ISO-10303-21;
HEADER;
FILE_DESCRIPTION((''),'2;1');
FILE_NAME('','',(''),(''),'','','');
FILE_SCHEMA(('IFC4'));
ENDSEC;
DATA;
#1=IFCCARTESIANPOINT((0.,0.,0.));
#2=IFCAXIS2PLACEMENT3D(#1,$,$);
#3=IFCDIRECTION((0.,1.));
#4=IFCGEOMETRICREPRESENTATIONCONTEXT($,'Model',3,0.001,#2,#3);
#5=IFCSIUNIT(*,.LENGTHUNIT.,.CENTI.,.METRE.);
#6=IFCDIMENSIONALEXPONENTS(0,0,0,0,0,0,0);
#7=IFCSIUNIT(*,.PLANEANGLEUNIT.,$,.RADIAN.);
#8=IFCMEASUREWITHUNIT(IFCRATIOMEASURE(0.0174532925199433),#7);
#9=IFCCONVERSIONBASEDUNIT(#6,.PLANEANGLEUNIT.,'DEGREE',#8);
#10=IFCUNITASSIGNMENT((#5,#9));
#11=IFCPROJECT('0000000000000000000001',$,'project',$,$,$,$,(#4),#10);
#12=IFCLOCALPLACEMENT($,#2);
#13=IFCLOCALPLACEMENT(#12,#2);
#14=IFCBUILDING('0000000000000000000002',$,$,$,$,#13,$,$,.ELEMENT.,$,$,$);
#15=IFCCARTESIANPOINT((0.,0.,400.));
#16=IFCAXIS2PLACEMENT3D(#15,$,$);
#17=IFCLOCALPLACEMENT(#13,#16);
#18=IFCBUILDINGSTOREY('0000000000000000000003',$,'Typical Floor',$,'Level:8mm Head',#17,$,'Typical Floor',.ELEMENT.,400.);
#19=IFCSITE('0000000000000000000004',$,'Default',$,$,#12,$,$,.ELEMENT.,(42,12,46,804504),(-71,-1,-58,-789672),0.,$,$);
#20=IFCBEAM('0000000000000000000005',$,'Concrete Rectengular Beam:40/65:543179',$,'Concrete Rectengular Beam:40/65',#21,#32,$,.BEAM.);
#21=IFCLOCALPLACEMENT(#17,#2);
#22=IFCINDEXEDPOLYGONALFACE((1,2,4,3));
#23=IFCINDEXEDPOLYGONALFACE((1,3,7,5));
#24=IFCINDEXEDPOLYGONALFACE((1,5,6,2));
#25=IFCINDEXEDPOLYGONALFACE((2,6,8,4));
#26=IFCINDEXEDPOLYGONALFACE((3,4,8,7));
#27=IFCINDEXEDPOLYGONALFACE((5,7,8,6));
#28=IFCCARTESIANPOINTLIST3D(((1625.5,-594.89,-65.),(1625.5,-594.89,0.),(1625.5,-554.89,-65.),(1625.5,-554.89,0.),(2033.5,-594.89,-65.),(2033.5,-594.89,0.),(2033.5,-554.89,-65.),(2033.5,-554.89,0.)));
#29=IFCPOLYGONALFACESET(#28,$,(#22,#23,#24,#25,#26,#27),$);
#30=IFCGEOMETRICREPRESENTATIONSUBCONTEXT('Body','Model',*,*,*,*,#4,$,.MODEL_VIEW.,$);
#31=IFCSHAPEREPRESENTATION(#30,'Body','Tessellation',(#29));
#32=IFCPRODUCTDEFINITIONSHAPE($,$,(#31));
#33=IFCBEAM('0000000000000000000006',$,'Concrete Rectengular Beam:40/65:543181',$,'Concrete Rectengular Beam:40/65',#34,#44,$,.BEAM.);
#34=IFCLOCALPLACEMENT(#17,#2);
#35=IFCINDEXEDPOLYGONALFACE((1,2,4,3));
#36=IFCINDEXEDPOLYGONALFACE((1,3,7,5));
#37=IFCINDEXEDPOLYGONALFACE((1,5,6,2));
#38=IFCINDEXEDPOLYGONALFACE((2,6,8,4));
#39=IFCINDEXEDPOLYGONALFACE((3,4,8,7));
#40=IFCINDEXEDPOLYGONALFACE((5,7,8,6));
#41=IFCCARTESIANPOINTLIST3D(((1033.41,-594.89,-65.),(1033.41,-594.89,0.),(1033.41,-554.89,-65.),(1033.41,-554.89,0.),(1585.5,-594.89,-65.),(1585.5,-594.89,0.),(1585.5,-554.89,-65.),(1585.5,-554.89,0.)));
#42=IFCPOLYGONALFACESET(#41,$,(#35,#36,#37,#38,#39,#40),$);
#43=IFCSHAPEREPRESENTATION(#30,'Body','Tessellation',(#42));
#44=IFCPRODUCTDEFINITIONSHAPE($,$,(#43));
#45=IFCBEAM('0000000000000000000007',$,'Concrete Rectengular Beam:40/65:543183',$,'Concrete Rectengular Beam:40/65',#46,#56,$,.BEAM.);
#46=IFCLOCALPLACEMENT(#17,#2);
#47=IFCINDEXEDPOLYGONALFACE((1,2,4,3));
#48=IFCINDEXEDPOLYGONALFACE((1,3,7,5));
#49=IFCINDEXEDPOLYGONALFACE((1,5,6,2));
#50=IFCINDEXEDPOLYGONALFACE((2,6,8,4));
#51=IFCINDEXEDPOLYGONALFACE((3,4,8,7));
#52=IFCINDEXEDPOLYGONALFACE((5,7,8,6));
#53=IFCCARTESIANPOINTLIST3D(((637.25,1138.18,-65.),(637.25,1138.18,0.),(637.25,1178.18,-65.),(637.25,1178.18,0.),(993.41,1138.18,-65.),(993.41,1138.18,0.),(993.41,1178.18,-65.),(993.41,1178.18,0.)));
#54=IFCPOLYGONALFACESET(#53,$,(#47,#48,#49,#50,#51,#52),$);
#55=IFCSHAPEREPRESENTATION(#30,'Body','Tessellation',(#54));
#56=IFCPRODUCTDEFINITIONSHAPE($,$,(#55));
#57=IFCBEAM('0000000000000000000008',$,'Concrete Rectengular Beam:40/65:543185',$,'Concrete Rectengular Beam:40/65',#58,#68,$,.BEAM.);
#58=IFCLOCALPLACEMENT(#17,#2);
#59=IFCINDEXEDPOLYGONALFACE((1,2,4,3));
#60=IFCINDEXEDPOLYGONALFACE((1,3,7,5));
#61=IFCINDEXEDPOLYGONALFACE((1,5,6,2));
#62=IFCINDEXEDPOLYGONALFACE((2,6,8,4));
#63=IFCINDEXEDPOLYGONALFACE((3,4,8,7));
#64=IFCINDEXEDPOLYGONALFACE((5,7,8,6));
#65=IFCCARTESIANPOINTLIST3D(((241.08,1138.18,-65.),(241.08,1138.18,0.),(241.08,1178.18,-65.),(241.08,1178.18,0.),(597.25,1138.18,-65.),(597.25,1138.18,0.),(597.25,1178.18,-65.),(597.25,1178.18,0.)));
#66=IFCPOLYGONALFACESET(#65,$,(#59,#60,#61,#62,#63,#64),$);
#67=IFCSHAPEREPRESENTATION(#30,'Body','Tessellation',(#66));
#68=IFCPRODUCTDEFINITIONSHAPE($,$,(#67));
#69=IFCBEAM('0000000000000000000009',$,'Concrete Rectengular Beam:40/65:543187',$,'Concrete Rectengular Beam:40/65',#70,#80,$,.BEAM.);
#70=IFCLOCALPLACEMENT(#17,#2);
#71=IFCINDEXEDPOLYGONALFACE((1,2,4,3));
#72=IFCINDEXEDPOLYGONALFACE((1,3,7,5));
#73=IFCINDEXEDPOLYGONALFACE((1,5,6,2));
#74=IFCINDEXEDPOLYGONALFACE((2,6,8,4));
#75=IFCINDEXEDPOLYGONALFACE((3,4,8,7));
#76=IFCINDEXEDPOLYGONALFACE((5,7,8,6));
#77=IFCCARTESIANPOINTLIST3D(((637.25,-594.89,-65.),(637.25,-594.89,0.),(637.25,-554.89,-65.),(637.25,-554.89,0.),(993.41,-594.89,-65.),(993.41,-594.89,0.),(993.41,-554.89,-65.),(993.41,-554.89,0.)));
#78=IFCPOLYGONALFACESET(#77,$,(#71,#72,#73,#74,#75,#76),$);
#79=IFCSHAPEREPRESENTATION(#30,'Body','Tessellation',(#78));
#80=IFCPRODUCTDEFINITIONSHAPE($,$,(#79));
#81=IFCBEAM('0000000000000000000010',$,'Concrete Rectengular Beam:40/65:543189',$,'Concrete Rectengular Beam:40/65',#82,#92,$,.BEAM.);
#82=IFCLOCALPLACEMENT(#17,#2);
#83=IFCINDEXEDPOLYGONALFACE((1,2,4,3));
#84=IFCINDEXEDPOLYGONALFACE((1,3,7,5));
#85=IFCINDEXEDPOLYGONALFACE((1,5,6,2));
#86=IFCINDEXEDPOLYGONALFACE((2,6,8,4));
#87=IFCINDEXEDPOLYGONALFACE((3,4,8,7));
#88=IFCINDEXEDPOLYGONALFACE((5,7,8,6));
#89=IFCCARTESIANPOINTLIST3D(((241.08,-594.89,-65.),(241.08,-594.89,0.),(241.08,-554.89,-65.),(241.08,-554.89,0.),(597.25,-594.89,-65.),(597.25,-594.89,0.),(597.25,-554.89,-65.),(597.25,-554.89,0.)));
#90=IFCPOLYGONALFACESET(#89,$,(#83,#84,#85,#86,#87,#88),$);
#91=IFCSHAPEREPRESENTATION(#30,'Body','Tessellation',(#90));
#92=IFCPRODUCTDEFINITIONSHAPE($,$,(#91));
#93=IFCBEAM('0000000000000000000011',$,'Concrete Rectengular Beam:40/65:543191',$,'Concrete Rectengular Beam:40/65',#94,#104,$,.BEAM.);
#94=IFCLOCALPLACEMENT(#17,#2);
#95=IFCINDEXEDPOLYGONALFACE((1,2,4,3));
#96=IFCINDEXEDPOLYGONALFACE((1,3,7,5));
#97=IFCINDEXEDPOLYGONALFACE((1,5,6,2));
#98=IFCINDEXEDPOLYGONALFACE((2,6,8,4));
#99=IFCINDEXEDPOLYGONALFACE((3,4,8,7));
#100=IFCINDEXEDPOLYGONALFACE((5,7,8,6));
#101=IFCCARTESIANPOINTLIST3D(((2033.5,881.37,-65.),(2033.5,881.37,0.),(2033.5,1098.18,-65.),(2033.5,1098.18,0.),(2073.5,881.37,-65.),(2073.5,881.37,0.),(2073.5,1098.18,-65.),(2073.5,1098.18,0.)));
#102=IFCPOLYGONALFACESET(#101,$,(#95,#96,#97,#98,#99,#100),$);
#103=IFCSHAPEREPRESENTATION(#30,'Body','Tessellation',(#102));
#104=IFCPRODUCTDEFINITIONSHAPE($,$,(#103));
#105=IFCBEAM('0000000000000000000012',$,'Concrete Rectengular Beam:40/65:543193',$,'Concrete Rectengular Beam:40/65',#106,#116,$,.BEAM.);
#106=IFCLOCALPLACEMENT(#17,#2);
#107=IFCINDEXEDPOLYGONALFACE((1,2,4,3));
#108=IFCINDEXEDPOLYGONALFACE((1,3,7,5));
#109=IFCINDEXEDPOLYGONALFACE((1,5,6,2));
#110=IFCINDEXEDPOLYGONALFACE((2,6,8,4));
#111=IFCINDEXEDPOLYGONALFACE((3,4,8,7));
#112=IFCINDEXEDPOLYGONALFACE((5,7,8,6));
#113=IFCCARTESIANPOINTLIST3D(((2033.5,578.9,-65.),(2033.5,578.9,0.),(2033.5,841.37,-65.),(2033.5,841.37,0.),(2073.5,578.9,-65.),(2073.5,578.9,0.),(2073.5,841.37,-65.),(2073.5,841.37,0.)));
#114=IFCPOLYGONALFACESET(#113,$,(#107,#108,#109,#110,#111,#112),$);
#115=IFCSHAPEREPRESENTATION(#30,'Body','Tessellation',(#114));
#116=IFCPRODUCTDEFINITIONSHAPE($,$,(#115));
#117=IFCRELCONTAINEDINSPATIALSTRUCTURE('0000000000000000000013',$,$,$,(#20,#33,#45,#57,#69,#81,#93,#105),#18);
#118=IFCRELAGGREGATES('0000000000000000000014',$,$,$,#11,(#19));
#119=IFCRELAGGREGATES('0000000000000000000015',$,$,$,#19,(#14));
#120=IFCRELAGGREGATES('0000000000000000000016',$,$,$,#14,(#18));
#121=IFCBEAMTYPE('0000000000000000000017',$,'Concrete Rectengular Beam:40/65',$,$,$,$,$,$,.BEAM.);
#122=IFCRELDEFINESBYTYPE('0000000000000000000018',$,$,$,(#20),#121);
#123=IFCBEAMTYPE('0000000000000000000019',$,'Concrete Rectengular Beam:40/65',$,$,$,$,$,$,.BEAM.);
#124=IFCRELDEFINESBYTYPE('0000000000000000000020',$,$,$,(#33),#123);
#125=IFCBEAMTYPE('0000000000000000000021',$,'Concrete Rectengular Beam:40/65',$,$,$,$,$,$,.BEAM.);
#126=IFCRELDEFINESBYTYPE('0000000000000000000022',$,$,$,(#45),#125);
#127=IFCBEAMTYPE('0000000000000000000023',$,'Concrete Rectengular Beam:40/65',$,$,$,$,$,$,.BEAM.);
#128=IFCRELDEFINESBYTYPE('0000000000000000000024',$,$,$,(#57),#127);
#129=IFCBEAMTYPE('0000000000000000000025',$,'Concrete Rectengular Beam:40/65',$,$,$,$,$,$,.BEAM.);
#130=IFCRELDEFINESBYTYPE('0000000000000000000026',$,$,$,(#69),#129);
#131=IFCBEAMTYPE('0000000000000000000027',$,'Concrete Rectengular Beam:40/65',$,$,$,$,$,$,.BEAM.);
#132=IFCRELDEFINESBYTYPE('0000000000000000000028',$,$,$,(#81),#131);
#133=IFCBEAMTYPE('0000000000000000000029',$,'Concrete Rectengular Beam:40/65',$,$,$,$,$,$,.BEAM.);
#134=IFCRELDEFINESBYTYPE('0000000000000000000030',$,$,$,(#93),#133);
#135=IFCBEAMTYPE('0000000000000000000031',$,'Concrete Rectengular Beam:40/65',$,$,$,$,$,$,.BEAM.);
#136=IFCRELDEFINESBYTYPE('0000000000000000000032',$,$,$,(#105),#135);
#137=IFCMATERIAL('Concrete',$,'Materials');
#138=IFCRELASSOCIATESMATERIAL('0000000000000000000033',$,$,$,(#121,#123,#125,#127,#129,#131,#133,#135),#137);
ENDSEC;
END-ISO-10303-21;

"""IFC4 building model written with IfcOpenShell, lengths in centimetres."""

from ifc_helpers import new_model, entity, si_unit, converted_unit, direction, frame, origin, place, context, subcontext, project, spatial, indexed_curve, outline, extrude, source, transform, mapped, material, type_object, type_shapes, element, save


model = new_model("IFC4")

# Units and contexts
model_context = context("Model", 3, precision=0.001, world=origin(), true_north=direction((0.0, 1.0)))
body_context = subcontext(model_context, "Body", "Model", "MODEL_VIEW")
ifc_project = project(units=[si_unit("LENGTHUNIT", "METRE", prefix="CENTI"), converted_unit("PLANEANGLEUNIT", "DEGREE", entity("IfcRatioMeasure", 0.0174532925199433), si_unit("PLANEANGLEUNIT", "RADIAN"), dimensions=[0, 0, 0, 0, 0, 0, 0])], contexts=[model_context])

# Site, building, storey
site_placement = place(None, origin())
site = spatial("IfcSite", under=ifc_project, at=site_placement, Name="Default", CompositionType="ELEMENT", RefLatitude=(42, 12, 46, 804504), RefLongitude=(-71, -1, -58, -789672), RefElevation=0.0)
building_placement = place(site_placement, origin())
building = spatial("IfcBuilding", under=site, at=building_placement, CompositionType="ELEMENT")
storey_placement = place(building_placement, frame((0.0, 0.0, 400.0)))
storey = spatial("IfcBuildingStorey", under=building, at=storey_placement, Name="Typical Floor", ObjectType="Level:8mm Head", LongName="Typical Floor", CompositionType="ELEMENT", Elevation=400.0)

# Beams
ifc_material = material(Name="Concrete", Category="Materials")
beam_type_1 = type_object("IfcBeamType", Name="Concrete Rectengular Beam:40/65", PredefinedType="BEAM", material=ifc_material)
shared_shape_1 = source(origin(), body_context, "Body", "SweptSolid", [
    extrude(outline(indexed_curve([(-32.5, -20.0), (32.5, -20.0), (32.5, 20.0), (-32.5, 20.0), (-32.5, -20.0)], self_intersect=False)), frame((2033.5, -574.89, 367.5), z_axis=(-1.0, 0.0, 0.0), x_axis=(0.0, 0.0, -1.0)), (0.0, 0.0, 1.0), 408.0),
])
type_shapes(beam_type_1, [shared_shape_1])
beam_1_placement = place(storey_placement, frame((0.0, 0.0, -400.0)))
element("IfcBeam", 1, at=beam_1_placement, inside=storey, type_object=beam_type_1, Name="Concrete Rectengular Beam:40/65:543179", ObjectType="Concrete Rectengular Beam:40/65", PredefinedType="BEAM", context=body_context, shape_type="MappedRepresentation", body=[
    mapped(shared_shape_1, transform((0.0, 0.0, 0.0), scale=1.0)),
])
beam_type_2 = type_object("IfcBeamType", Name="Concrete Rectengular Beam:40/65", PredefinedType="BEAM", material=ifc_material)
shared_shape_2 = source(origin(), body_context, "Body", "SweptSolid", [
    extrude(outline(indexed_curve([(-32.5, -20.0), (32.5, -20.0), (32.5, 20.0), (-32.5, 20.0), (-32.5, -20.0)], self_intersect=False)), frame((1585.5, -574.89, 367.5), z_axis=(-1.0, 0.0, 0.0), x_axis=(0.0, 0.0, -1.0)), (0.0, 0.0, 1.0), 552.09),
])
type_shapes(beam_type_2, [shared_shape_2])
beam_2_placement = place(storey_placement, frame((0.0, 0.0, -400.0)))
element("IfcBeam", 2, at=beam_2_placement, inside=storey, type_object=beam_type_2, Name="Concrete Rectengular Beam:40/65:543181", ObjectType="Concrete Rectengular Beam:40/65", PredefinedType="BEAM", context=body_context, shape_type="MappedRepresentation", body=[
    mapped(shared_shape_2, transform((0.0, 0.0, 0.0), scale=1.0)),
])
beam_type_3 = type_object("IfcBeamType", Name="Concrete Rectengular Beam:40/65", PredefinedType="BEAM", material=ifc_material)
shared_shape_3 = source(origin(), body_context, "Body", "SweptSolid", [
    extrude(outline(indexed_curve([(-32.5, -20.0), (32.5, -20.0), (32.5, 20.0), (-32.5, 20.0), (-32.5, -20.0)], self_intersect=False)), frame((993.41, 1158.18, 367.5), z_axis=(-1.0, 0.0, 0.0), x_axis=(0.0, 0.0, -1.0)), (0.0, 0.0, 1.0), 356.17),
])
type_shapes(beam_type_3, [shared_shape_3])
beam_3_placement = place(storey_placement, frame((0.0, 0.0, -400.0)))
element("IfcBeam", 3, at=beam_3_placement, inside=storey, type_object=beam_type_3, Name="Concrete Rectengular Beam:40/65:543183", ObjectType="Concrete Rectengular Beam:40/65", PredefinedType="BEAM", context=body_context, shape_type="MappedRepresentation", body=[
    mapped(shared_shape_3, transform((0.0, 0.0, 0.0), scale=1.0)),
])
beam_type_4 = type_object("IfcBeamType", Name="Concrete Rectengular Beam:40/65", PredefinedType="BEAM", material=ifc_material)
shared_shape_4 = source(origin(), body_context, "Body", "SweptSolid", [
    extrude(outline(indexed_curve([(-32.5, -20.0), (32.5, -20.0), (32.5, 20.0), (-32.5, 20.0), (-32.5, -20.0)], self_intersect=False)), frame((597.25, 1158.18, 367.5), z_axis=(-1.0, 0.0, 0.0), x_axis=(0.0, 0.0, -1.0)), (0.0, 0.0, 1.0), 356.17),
])
type_shapes(beam_type_4, [shared_shape_4])
beam_4_placement = place(storey_placement, frame((0.0, 0.0, -400.0)))
element("IfcBeam", 4, at=beam_4_placement, inside=storey, type_object=beam_type_4, Name="Concrete Rectengular Beam:40/65:543185", ObjectType="Concrete Rectengular Beam:40/65", PredefinedType="BEAM", context=body_context, shape_type="MappedRepresentation", body=[
    mapped(shared_shape_4, transform((0.0, 0.0, 0.0), scale=1.0)),
])
beam_type_5 = type_object("IfcBeamType", Name="Concrete Rectengular Beam:40/65", PredefinedType="BEAM", material=ifc_material)
shared_shape_5 = source(origin(), body_context, "Body", "SweptSolid", [
    extrude(outline(indexed_curve([(-32.5, -20.0), (32.5, -20.0), (32.5, 20.0), (-32.5, 20.0), (-32.5, -20.0)], self_intersect=False)), frame((993.41, -574.89, 367.5), z_axis=(-1.0, 0.0, 0.0), x_axis=(0.0, 0.0, -1.0)), (0.0, 0.0, 1.0), 356.17),
])
type_shapes(beam_type_5, [shared_shape_5])
beam_5_placement = place(storey_placement, frame((0.0, 0.0, -400.0)))
element("IfcBeam", 5, at=beam_5_placement, inside=storey, type_object=beam_type_5, Name="Concrete Rectengular Beam:40/65:543187", ObjectType="Concrete Rectengular Beam:40/65", PredefinedType="BEAM", context=body_context, shape_type="MappedRepresentation", body=[
    mapped(shared_shape_5, transform((0.0, 0.0, 0.0), scale=1.0)),
])
beam_type_6 = type_object("IfcBeamType", Name="Concrete Rectengular Beam:40/65", PredefinedType="BEAM", material=ifc_material)
shared_shape_6 = source(origin(), body_context, "Body", "SweptSolid", [
    extrude(outline(indexed_curve([(-32.5, -20.0), (32.5, -20.0), (32.5, 20.0), (-32.5, 20.0), (-32.5, -20.0)], self_intersect=False)), frame((597.25, -574.89, 367.5), z_axis=(-1.0, 0.0, 0.0), x_axis=(0.0, 0.0, -1.0)), (0.0, 0.0, 1.0), 356.17),
])
type_shapes(beam_type_6, [shared_shape_6])
beam_6_placement = place(storey_placement, frame((0.0, 0.0, -400.0)))
element("IfcBeam", 6, at=beam_6_placement, inside=storey, type_object=beam_type_6, Name="Concrete Rectengular Beam:40/65:543189", ObjectType="Concrete Rectengular Beam:40/65", PredefinedType="BEAM", context=body_context, shape_type="MappedRepresentation", body=[
    mapped(shared_shape_6, transform((0.0, 0.0, 0.0), scale=1.0)),
])
beam_type_7 = type_object("IfcBeamType", Name="Concrete Rectengular Beam:40/65", PredefinedType="BEAM", material=ifc_material)
shared_shape_7 = source(origin(), body_context, "Body", "SweptSolid", [
    extrude(outline(indexed_curve([(-20.0, -32.5), (20.0, -32.5), (20.0, 32.5), (-20.0, 32.5), (-20.0, -32.5)], self_intersect=False)), frame((2053.5, 1098.18, 367.5), z_axis=(0.0, -1.0, 0.0), x_axis=(-1.0, 0.0, 0.0)), (0.0, 0.0, 1.0), 216.81),
])
type_shapes(beam_type_7, [shared_shape_7])
beam_7_placement = place(storey_placement, frame((0.0, 0.0, -400.0)))
element("IfcBeam", 7, at=beam_7_placement, inside=storey, type_object=beam_type_7, Name="Concrete Rectengular Beam:40/65:543191", ObjectType="Concrete Rectengular Beam:40/65", PredefinedType="BEAM", context=body_context, shape_type="MappedRepresentation", body=[
    mapped(shared_shape_7, transform((0.0, 0.0, 0.0), scale=1.0)),
])
beam_type_8 = type_object("IfcBeamType", Name="Concrete Rectengular Beam:40/65", PredefinedType="BEAM", material=ifc_material)
shared_shape_8 = source(origin(), body_context, "Body", "SweptSolid", [
    extrude(outline(indexed_curve([(-20.0, -32.5), (20.0, -32.5), (20.0, 32.5), (-20.0, 32.5), (-20.0, -32.5)], self_intersect=False)), frame((2053.5, 841.37, 367.5), z_axis=(0.0, -1.0, 0.0), x_axis=(-1.0, 0.0, 0.0)), (0.0, 0.0, 1.0), 262.47),
])
type_shapes(beam_type_8, [shared_shape_8])
beam_8_placement = place(storey_placement, frame((0.0, 0.0, -400.0)))
element("IfcBeam", 8, at=beam_8_placement, inside=storey, type_object=beam_type_8, Name="Concrete Rectengular Beam:40/65:543193", ObjectType="Concrete Rectengular Beam:40/65", PredefinedType="BEAM", context=body_context, shape_type="MappedRepresentation", body=[
    mapped(shared_shape_8, transform((0.0, 0.0, 0.0), scale=1.0)),
])

save(model, "model.ifc")
